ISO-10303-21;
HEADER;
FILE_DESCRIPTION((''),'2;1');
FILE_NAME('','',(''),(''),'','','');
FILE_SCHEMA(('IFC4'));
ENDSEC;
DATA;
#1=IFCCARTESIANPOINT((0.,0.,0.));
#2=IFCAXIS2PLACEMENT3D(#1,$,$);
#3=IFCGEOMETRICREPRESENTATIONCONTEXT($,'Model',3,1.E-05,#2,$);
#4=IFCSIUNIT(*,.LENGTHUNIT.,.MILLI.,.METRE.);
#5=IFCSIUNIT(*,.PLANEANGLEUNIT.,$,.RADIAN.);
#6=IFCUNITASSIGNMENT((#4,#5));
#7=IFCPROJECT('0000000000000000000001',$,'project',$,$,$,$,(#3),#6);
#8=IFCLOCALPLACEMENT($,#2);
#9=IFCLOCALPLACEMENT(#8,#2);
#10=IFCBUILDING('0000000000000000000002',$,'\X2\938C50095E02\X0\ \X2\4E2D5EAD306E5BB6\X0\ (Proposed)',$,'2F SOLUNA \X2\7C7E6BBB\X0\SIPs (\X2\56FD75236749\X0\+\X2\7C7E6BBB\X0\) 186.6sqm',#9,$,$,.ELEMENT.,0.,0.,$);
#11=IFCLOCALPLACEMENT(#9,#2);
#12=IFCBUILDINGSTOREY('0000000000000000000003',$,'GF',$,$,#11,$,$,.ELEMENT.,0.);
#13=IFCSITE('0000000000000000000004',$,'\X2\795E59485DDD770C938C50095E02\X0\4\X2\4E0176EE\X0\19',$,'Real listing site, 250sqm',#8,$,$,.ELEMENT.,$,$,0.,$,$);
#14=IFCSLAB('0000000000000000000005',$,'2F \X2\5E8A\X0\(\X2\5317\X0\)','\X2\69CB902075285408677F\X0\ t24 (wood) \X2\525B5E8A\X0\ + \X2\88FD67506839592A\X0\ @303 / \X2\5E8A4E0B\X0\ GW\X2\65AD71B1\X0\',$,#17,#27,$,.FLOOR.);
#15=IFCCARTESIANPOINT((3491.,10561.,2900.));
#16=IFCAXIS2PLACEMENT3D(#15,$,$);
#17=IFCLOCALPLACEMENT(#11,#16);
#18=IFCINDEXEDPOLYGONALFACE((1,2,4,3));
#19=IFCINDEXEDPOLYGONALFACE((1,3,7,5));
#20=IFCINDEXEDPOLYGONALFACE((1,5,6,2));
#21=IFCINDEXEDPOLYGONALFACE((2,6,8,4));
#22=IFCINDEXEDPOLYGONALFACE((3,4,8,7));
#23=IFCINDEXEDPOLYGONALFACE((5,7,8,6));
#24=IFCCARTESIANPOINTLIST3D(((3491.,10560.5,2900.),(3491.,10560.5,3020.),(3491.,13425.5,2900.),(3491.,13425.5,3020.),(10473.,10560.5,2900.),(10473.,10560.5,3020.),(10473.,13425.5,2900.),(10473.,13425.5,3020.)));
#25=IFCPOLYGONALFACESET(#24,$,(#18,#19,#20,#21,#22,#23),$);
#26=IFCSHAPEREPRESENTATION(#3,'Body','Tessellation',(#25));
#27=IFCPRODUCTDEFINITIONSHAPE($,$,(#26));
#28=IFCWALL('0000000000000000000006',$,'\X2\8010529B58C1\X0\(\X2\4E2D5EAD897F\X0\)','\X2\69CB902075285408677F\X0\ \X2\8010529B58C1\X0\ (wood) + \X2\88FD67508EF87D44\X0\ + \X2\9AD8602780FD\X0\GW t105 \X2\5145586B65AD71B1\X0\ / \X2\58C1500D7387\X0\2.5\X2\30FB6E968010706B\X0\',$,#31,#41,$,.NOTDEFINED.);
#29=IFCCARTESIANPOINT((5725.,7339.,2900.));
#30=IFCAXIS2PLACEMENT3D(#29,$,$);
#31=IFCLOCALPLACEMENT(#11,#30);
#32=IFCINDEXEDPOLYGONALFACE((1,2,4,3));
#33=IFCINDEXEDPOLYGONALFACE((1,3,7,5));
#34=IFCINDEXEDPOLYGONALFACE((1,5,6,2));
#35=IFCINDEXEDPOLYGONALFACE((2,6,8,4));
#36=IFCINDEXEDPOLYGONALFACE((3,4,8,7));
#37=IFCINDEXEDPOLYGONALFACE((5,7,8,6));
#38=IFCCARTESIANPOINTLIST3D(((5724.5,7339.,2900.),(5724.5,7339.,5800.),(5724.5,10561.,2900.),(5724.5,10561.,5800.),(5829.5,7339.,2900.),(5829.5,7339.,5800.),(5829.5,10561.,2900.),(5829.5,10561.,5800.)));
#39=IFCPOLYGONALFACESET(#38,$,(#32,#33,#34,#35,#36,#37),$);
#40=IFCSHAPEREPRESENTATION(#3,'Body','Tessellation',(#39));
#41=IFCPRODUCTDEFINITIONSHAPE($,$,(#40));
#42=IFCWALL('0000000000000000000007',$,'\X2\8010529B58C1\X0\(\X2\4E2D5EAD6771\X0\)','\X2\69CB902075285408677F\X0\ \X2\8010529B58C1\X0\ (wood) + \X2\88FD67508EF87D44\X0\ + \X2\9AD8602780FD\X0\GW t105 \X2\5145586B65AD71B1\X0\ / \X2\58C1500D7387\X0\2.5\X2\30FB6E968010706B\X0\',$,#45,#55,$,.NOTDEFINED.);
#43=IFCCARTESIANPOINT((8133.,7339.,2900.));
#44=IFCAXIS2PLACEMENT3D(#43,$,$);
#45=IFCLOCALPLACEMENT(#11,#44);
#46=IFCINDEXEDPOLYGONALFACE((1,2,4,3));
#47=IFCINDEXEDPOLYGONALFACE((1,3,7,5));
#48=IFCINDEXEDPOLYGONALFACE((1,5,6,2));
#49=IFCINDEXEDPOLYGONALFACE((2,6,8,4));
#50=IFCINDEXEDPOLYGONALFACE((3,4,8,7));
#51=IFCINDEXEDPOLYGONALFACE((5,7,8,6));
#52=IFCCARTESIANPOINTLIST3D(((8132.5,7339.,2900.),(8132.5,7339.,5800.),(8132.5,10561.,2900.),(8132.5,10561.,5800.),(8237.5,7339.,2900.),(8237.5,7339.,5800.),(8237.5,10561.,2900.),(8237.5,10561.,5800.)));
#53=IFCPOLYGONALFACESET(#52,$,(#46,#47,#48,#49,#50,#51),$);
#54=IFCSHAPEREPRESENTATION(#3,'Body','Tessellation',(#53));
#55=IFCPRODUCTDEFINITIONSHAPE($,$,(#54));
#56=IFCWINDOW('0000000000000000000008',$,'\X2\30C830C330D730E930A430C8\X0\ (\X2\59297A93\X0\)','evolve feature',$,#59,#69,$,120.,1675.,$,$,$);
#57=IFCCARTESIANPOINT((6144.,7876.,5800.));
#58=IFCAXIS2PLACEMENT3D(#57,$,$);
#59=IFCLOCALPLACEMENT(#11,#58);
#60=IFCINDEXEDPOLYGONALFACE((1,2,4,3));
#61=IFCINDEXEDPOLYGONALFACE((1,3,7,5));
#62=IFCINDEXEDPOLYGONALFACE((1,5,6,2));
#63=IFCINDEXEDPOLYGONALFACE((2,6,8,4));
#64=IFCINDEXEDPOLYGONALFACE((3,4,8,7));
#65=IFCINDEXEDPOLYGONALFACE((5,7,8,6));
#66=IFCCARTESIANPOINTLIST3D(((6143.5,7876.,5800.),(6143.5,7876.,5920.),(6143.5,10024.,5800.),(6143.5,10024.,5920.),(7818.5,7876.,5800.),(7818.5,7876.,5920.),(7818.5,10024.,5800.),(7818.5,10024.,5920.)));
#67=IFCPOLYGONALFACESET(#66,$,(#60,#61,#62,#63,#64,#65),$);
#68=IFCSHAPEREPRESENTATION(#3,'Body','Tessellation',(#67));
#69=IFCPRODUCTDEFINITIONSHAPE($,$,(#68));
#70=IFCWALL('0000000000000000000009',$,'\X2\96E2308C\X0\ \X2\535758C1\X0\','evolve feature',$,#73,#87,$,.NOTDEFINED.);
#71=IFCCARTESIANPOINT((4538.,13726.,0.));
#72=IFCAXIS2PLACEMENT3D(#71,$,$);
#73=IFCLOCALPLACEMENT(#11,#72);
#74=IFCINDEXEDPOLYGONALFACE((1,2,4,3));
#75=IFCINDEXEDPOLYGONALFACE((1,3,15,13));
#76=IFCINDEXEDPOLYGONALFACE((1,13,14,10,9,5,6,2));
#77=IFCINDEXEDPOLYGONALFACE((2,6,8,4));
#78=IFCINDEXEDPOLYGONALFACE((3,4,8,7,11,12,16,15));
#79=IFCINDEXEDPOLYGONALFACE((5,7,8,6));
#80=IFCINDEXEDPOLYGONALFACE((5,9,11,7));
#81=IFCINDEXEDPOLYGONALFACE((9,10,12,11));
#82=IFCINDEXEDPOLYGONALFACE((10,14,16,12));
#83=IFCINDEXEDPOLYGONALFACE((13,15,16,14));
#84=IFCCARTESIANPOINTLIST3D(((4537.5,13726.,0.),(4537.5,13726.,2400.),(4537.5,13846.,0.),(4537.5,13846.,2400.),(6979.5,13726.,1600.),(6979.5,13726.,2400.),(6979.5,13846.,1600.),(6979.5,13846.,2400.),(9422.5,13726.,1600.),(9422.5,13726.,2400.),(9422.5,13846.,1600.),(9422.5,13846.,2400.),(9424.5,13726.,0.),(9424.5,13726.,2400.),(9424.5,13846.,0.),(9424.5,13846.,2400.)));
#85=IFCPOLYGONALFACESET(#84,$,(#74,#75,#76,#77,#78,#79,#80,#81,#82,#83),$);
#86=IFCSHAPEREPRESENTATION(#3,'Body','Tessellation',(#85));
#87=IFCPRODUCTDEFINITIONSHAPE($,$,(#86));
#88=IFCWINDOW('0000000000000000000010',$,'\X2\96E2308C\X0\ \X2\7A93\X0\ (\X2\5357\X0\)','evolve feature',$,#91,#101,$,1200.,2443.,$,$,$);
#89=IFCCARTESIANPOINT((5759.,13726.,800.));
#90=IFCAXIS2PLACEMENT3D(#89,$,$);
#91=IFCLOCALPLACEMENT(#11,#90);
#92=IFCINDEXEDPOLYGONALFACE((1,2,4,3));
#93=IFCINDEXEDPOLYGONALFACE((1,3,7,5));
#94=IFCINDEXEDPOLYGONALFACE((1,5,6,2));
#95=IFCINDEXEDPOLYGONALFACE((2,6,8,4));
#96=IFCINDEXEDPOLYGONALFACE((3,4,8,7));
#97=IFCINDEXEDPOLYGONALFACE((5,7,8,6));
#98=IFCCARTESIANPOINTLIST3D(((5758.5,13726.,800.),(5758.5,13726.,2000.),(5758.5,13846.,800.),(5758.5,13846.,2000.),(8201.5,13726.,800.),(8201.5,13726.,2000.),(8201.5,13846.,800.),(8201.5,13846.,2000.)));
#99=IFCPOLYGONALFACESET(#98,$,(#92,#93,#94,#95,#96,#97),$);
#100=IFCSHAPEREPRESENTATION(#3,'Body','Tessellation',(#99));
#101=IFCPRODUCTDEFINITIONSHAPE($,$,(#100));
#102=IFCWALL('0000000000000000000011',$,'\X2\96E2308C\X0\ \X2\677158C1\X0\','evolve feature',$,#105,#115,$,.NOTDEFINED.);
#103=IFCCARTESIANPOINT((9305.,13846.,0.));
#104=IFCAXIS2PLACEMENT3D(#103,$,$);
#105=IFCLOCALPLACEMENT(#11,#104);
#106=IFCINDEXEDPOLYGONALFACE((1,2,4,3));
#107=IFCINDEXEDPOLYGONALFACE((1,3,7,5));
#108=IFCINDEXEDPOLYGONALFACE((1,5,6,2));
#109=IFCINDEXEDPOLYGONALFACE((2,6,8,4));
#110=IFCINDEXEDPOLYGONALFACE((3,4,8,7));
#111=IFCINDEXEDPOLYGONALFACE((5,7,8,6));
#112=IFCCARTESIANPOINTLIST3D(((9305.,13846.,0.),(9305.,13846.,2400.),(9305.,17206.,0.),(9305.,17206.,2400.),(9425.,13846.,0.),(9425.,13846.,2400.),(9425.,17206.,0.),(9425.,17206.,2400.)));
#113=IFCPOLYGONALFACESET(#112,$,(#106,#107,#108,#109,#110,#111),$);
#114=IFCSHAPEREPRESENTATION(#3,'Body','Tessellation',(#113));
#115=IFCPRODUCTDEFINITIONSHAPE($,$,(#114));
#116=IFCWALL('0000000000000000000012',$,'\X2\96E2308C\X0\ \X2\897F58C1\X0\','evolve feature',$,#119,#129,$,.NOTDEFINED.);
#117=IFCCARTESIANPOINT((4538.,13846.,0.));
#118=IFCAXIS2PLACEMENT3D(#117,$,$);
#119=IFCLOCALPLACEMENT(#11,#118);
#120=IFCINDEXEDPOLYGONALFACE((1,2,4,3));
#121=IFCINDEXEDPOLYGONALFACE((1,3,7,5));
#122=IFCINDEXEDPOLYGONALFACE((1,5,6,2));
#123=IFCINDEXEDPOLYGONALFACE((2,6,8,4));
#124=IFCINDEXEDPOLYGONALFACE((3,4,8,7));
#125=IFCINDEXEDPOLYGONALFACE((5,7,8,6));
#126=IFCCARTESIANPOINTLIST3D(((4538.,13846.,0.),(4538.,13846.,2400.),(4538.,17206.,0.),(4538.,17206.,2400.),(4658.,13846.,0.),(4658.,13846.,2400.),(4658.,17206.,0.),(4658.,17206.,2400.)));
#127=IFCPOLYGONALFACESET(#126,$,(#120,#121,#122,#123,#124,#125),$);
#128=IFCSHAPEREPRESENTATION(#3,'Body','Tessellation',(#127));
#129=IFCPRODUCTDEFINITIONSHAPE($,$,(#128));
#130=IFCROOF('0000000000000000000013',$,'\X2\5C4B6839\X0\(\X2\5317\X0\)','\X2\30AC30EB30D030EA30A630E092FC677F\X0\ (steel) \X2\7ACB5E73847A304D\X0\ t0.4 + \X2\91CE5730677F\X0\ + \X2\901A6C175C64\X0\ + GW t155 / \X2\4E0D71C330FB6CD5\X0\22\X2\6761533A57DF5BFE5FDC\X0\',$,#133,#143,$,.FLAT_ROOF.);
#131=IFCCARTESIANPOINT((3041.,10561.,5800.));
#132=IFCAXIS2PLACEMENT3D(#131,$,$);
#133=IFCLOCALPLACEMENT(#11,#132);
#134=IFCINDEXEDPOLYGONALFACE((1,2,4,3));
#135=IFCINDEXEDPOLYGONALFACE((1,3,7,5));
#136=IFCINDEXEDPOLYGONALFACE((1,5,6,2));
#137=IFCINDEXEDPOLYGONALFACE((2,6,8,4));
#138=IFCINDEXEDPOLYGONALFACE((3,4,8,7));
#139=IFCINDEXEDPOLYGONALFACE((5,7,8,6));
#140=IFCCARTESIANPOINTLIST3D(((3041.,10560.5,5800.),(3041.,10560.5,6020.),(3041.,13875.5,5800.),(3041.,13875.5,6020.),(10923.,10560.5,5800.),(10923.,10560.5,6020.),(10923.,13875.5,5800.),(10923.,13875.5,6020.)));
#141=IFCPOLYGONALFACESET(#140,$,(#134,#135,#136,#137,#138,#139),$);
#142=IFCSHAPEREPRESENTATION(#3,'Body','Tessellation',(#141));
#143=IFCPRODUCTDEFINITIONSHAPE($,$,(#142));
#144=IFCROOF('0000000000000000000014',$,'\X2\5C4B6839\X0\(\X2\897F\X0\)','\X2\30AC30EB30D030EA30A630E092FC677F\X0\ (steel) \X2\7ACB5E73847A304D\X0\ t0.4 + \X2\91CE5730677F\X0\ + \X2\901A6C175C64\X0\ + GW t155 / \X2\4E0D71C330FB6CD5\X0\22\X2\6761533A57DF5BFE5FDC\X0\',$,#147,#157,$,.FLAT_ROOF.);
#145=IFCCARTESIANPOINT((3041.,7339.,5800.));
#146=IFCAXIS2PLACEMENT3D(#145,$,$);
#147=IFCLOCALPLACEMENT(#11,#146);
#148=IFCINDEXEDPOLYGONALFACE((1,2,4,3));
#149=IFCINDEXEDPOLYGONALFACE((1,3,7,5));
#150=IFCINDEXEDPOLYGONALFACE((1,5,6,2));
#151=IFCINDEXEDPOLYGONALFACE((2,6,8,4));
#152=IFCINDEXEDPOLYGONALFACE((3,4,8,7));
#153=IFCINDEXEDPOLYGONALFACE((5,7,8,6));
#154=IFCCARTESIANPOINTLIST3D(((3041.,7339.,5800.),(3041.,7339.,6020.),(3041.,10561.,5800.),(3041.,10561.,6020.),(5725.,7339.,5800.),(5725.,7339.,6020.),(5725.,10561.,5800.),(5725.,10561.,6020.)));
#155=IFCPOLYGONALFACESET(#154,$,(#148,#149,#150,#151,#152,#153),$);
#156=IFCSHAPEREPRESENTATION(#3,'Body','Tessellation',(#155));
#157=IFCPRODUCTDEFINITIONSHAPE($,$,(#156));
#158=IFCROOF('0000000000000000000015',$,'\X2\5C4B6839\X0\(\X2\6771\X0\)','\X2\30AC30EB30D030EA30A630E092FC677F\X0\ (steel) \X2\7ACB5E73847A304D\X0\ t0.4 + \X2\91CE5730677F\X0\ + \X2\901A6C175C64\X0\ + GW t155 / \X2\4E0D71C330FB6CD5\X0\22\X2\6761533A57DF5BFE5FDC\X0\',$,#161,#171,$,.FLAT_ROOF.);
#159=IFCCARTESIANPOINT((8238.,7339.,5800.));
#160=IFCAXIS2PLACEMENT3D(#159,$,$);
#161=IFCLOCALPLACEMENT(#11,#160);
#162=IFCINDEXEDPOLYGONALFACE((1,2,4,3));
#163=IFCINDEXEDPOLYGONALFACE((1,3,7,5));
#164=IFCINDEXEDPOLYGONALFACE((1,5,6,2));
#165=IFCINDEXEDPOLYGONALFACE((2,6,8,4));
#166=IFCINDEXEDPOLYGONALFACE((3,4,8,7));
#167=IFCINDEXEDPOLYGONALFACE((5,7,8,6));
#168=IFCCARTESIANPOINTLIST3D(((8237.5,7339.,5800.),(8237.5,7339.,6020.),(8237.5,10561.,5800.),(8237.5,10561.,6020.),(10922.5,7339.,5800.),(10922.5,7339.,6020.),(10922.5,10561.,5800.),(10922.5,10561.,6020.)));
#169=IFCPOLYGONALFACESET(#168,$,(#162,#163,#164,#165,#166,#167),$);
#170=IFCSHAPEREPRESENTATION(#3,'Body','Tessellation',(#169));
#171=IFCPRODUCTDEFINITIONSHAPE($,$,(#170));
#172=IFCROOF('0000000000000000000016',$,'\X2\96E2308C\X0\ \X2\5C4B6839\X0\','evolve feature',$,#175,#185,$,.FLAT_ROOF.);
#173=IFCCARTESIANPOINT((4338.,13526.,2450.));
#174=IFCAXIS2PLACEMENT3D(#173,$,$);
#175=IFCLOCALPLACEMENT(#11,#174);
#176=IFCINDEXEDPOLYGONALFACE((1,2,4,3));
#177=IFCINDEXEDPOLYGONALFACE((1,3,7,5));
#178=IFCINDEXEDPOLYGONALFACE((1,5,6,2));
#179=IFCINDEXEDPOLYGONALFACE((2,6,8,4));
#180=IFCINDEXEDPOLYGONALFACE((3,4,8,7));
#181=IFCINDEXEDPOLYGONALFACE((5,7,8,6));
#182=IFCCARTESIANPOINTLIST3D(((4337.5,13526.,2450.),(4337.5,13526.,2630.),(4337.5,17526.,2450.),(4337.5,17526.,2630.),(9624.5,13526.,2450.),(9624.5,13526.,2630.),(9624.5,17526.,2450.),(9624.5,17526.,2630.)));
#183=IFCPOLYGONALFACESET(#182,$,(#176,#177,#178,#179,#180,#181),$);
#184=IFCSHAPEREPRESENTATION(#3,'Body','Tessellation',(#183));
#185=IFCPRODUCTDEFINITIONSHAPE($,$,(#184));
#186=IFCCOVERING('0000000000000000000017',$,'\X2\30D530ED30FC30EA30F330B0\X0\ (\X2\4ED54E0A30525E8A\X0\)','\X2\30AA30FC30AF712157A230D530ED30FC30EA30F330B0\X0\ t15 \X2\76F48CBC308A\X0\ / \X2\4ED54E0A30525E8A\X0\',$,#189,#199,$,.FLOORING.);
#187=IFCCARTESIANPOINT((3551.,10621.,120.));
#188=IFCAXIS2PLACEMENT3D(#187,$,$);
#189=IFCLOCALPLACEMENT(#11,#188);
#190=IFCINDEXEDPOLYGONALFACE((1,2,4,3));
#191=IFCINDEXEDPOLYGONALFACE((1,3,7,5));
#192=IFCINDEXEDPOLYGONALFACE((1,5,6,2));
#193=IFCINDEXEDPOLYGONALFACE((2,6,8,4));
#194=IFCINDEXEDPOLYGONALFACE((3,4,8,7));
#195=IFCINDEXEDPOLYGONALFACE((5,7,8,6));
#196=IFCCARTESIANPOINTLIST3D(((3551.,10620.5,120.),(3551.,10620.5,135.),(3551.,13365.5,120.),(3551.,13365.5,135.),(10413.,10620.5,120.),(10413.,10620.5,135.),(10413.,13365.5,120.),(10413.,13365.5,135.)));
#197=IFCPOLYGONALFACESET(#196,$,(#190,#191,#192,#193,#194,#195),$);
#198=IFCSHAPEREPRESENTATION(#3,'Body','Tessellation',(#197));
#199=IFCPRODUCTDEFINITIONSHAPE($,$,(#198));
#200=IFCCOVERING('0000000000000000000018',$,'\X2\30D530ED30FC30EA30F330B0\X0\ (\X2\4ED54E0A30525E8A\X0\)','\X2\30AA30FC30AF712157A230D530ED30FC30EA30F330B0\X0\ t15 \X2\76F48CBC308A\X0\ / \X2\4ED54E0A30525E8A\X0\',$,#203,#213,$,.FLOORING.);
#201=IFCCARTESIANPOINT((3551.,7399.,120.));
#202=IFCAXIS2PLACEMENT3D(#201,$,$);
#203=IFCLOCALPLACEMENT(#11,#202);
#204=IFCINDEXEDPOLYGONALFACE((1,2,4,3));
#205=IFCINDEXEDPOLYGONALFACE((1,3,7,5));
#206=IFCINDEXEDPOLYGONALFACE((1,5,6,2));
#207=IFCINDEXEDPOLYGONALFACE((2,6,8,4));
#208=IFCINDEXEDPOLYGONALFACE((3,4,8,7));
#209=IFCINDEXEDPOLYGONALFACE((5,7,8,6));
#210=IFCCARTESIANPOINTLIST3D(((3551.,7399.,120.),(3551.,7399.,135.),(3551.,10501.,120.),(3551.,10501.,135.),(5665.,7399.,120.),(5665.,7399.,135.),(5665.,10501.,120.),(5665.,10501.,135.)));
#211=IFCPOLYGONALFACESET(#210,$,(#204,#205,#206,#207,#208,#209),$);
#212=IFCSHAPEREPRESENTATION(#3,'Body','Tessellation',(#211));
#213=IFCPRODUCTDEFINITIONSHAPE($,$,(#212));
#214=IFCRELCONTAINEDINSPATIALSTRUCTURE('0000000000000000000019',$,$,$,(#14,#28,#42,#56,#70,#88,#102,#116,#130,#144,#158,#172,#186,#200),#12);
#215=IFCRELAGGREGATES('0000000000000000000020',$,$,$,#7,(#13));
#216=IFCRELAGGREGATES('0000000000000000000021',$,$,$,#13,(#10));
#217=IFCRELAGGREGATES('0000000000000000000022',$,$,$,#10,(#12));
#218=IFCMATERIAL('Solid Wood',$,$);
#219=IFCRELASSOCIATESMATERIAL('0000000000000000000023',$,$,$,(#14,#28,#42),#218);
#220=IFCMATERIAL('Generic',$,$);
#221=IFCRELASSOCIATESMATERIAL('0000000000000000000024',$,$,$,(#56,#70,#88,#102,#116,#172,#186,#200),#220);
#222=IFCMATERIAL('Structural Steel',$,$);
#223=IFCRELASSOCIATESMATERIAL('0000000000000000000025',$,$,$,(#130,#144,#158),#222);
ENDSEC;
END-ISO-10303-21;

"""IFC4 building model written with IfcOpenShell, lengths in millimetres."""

from ifc_helpers import new_model, si_unit, frame, frame_2d, origin, place, context, project, spatial, rectangle, extrude, material, element, fill, save


model = new_model("IFC4")

# Units and contexts
model_context = context("Model", 3, precision=1e-05, world=origin())
ifc_project = project(units=[si_unit("LENGTHUNIT", "METRE", prefix="MILLI"), si_unit("PLANEANGLEUNIT", "RADIAN")], contexts=[model_context])

# Site, building, storey
site_placement = place(None, origin())
site = spatial("IfcSite", under=ifc_project, at=site_placement, Name="神奈川県鎌倉市4丁目19", ObjectType="Real listing site, 250sqm", CompositionType="ELEMENT", RefElevation=0.0)
building_placement = place(site_placement, origin())
building = spatial("IfcBuilding", under=site, at=building_placement, Name="鎌倉市 中庭の家 (Proposed)", ObjectType="2F SOLUNA 籾殻SIPs (国産杉+籾殻) 186.6sqm", CompositionType="ELEMENT", ElevationOfRefHeight=0.0, ElevationOfTerrain=0.0)
storey_placement = place(building_placement, origin())
storey = spatial("IfcBuildingStorey", under=building, at=storey_placement, Name="GF", CompositionType="ELEMENT", Elevation=0.0)

# Slab
ifc_material_1 = material(Name="Solid Wood")
slab_1_placement = place(storey_placement, frame((3491.0, 10561.0, 2900.0)))
element("IfcSlab", 1, at=slab_1_placement, inside=storey, material=ifc_material_1, Name="2F 床(北)", Description="構造用合板 t24 (wood) 剛床 + 製材根太 @303 / 床下 GW断熱", PredefinedType="FLOOR", context=model_context, shape_type="SweptSolid", body=[
    extrude(rectangle(XDim=6982.0, YDim=2865.0, at=frame_2d((3491.0, 1432.0))), frame((3491.0, 10561.0, 2900.0)), (0.0, 0.0, 1.0), 120.0),
])
ifc_material_2 = material(Name="Generic")

# Walls
wall_1_placement = place(storey_placement, frame((5725.0, 7339.0, 2900.0)))
element("IfcWall", 2, at=wall_1_placement, inside=storey, material=ifc_material_1, Name="耐力壁(中庭西)", Description="構造用合板 耐力壁 (wood) + 製材軸組 + 高性能GW t105 充填断熱 / 壁倍率2.5・準耐火", PredefinedType="NOTDEFINED", context=model_context, shape_type="SweptSolid", body=[
    extrude(rectangle(XDim=105.0, YDim=3222.0, at=frame_2d((52.0, 1611.0))), frame((5725.0, 7339.0, 2900.0)), (0.0, 0.0, 1.0), 2900.0),
])
wall_2_placement = place(storey_placement, frame((8133.0, 7339.0, 2900.0)))
element("IfcWall", 3, at=wall_2_placement, inside=storey, material=ifc_material_1, Name="耐力壁(中庭東)", Description="構造用合板 耐力壁 (wood) + 製材軸組 + 高性能GW t105 充填断熱 / 壁倍率2.5・準耐火", PredefinedType="NOTDEFINED", context=model_context, shape_type="SweptSolid", body=[
    extrude(rectangle(XDim=105.0, YDim=3222.0, at=frame_2d((52.0, 1611.0))), frame((8133.0, 7339.0, 2900.0)), (0.0, 0.0, 1.0), 2900.0),
])

# Window
window_1_placement = place(storey_placement, frame((6144.0, 7876.0, 5800.0)))
element("IfcWindow", 4, at=window_1_placement, inside=storey, material=ifc_material_2, Name="トップライト (天窓)", Description="evolve feature", OverallHeight=120.0, OverallWidth=1675.0, context=model_context, shape_type="SweptSolid", body=[
    extrude(rectangle(XDim=1675.0, YDim=2148.0, at=frame_2d((837.0, 1074.0))), frame((6144.0, 7876.0, 5800.0)), (0.0, 0.0, 1.0), 120.0),
])

# Wall, opening, window
wall_3_placement = place(storey_placement, frame((4538.0, 13726.0, 0.0)))
wall_3 = element("IfcWall", 5, at=wall_3_placement, inside=storey, material=ifc_material_2, Name="離れ 南壁", Description="evolve feature", PredefinedType="NOTDEFINED", context=model_context, shape_type="SweptSolid", body=[
    extrude(rectangle(XDim=4887.0, YDim=120.0, at=frame_2d((2443.0, 60.0))), frame((4538.0, 13726.0, 0.0)), (0.0, 0.0, 1.0), 2400.0),
])
opening_1_placement = place(storey_placement, frame((5759.0, 13726.0, 800.0)))
opening_1 = element("IfcOpeningElement", 6, at=opening_1_placement, cuts=wall_3, PredefinedType="NOTDEFINED", context=model_context, shape_type="SweptSolid", body=[
    extrude(rectangle(XDim=2443.0, YDim=120.0, at=frame_2d((1221.0, 60.0))), frame((5759.0, 13726.0, 800.0)), (0.0, 0.0, 1.0), 1200.0),
])
window_2_placement = place(storey_placement, frame((5759.0, 13726.0, 800.0)))
window_2 = element("IfcWindow", 7, at=window_2_placement, inside=storey, material=ifc_material_2, Name="離れ 窓 (南)", Description="evolve feature", OverallHeight=1200.0, OverallWidth=2443.0, context=model_context, shape_type="SweptSolid", body=[
    extrude(rectangle(XDim=2443.0, YDim=120.0, at=frame_2d((1221.0, 60.0))), frame((5759.0, 13726.0, 800.0)), (0.0, 0.0, 1.0), 1200.0),
])
fill(opening_1, window_2)

# Walls
wall_4_placement = place(storey_placement, frame((9305.0, 13846.0, 0.0)))
element("IfcWall", 8, at=wall_4_placement, inside=storey, material=ifc_material_2, Name="離れ 東壁", Description="evolve feature", PredefinedType="NOTDEFINED", context=model_context, shape_type="SweptSolid", body=[
    extrude(rectangle(XDim=120.0, YDim=3360.0, at=frame_2d((60.0, 1680.0))), frame((9305.0, 13846.0, 0.0)), (0.0, 0.0, 1.0), 2400.0),
])
wall_5_placement = place(storey_placement, frame((4538.0, 13846.0, 0.0)))
element("IfcWall", 9, at=wall_5_placement, inside=storey, material=ifc_material_2, Name="離れ 西壁", Description="evolve feature", PredefinedType="NOTDEFINED", context=model_context, shape_type="SweptSolid", body=[
    extrude(rectangle(XDim=120.0, YDim=3360.0, at=frame_2d((60.0, 1680.0))), frame((4538.0, 13846.0, 0.0)), (0.0, 0.0, 1.0), 2400.0),
])

# Roofs
ifc_material_3 = material(Name="Structural Steel")
for number, where, name in (
    (10, (3041.0, 10561.0, 5800.0), "屋根(北)"),
):
    element("IfcRoof", number, at=place(storey_placement, frame(where)), inside=storey, material=ifc_material_3, Name=name, Description="ガルバリウム鋼板 (steel) 立平葺き t0.4 + 野地板 + 通気層 + GW t155 / 不燃・法22条区域対応", PredefinedType="FLAT_ROOF", context=model_context, shape_type="SweptSolid", body=[
        extrude(rectangle(XDim=7882.0, YDim=3315.0, at=frame_2d((3941.0, 1657.0))), frame((3041.0, 10561.0, 5800.0)), (0.0, 0.0, 1.0), 220.0),
    ])
roof_1_placement = place(storey_placement, frame((3041.0, 7339.0, 5800.0)))
element("IfcRoof", 11, at=roof_1_placement, inside=storey, material=ifc_material_3, Name="屋根(西)", Description="ガルバリウム鋼板 (steel) 立平葺き t0.4 + 野地板 + 通気層 + GW t155 / 不燃・法22条区域対応", PredefinedType="FLAT_ROOF", context=model_context, shape_type="SweptSolid", body=[
    extrude(rectangle(XDim=2684.0, YDim=3222.0, at=frame_2d((1342.0, 1611.0))), frame((3041.0, 7339.0, 5800.0)), (0.0, 0.0, 1.0), 220.0),
])
roof_2_placement = place(storey_placement, frame((8238.0, 7339.0, 5800.0)))
element("IfcRoof", 12, at=roof_2_placement, inside=storey, material=ifc_material_3, Name="屋根(東)", Description="ガルバリウム鋼板 (steel) 立平葺き t0.4 + 野地板 + 通気層 + GW t155 / 不燃・法22条区域対応", PredefinedType="FLAT_ROOF", context=model_context, shape_type="SweptSolid", body=[
    extrude(rectangle(XDim=2685.0, YDim=3222.0, at=frame_2d((1342.0, 1611.0))), frame((8238.0, 7339.0, 5800.0)), (0.0, 0.0, 1.0), 220.0),
])
roof_3_placement = place(storey_placement, frame((4338.0, 13526.0, 2450.0)))
element("IfcRoof", 13, at=roof_3_placement, inside=storey, material=ifc_material_2, Name="離れ 屋根", Description="evolve feature", PredefinedType="FLAT_ROOF", context=model_context, shape_type="SweptSolid", body=[
    extrude(rectangle(XDim=5287.0, YDim=4000.0, at=frame_2d((2643.0, 2000.0))), frame((4338.0, 13526.0, 2450.0)), (0.0, 0.0, 1.0), 180.0),
])

# Coverings
covering_1_placement = place(storey_placement, frame((3551.0, 10621.0, 120.0)))
element("IfcCovering", 14, at=covering_1_placement, inside=storey, material=ifc_material_2, Name="フローリング (仕上げ床)", Description="オーク無垢フローリング t15 直貼り / 仕上げ床", PredefinedType="FLOORING", context=model_context, shape_type="SweptSolid", body=[
    extrude(rectangle(XDim=6862.0, YDim=2745.0, at=frame_2d((3431.0, 1372.0))), frame((3551.0, 10621.0, 120.0)), (0.0, 0.0, 1.0), 15.0),
])
covering_2_placement = place(storey_placement, frame((3551.0, 7399.0, 120.0)))
element("IfcCovering", 15, at=covering_2_placement, inside=storey, material=ifc_material_2, Name="フローリング (仕上げ床)", Description="オーク無垢フローリング t15 直貼り / 仕上げ床", PredefinedType="FLOORING", context=model_context, shape_type="SweptSolid", body=[
    extrude(rectangle(XDim=2114.0, YDim=3102.0, at=frame_2d((1057.0, 1551.0))), frame((3551.0, 7399.0, 120.0)), (0.0, 0.0, 1.0), 15.0),
])

save(model, "model.ifc")
